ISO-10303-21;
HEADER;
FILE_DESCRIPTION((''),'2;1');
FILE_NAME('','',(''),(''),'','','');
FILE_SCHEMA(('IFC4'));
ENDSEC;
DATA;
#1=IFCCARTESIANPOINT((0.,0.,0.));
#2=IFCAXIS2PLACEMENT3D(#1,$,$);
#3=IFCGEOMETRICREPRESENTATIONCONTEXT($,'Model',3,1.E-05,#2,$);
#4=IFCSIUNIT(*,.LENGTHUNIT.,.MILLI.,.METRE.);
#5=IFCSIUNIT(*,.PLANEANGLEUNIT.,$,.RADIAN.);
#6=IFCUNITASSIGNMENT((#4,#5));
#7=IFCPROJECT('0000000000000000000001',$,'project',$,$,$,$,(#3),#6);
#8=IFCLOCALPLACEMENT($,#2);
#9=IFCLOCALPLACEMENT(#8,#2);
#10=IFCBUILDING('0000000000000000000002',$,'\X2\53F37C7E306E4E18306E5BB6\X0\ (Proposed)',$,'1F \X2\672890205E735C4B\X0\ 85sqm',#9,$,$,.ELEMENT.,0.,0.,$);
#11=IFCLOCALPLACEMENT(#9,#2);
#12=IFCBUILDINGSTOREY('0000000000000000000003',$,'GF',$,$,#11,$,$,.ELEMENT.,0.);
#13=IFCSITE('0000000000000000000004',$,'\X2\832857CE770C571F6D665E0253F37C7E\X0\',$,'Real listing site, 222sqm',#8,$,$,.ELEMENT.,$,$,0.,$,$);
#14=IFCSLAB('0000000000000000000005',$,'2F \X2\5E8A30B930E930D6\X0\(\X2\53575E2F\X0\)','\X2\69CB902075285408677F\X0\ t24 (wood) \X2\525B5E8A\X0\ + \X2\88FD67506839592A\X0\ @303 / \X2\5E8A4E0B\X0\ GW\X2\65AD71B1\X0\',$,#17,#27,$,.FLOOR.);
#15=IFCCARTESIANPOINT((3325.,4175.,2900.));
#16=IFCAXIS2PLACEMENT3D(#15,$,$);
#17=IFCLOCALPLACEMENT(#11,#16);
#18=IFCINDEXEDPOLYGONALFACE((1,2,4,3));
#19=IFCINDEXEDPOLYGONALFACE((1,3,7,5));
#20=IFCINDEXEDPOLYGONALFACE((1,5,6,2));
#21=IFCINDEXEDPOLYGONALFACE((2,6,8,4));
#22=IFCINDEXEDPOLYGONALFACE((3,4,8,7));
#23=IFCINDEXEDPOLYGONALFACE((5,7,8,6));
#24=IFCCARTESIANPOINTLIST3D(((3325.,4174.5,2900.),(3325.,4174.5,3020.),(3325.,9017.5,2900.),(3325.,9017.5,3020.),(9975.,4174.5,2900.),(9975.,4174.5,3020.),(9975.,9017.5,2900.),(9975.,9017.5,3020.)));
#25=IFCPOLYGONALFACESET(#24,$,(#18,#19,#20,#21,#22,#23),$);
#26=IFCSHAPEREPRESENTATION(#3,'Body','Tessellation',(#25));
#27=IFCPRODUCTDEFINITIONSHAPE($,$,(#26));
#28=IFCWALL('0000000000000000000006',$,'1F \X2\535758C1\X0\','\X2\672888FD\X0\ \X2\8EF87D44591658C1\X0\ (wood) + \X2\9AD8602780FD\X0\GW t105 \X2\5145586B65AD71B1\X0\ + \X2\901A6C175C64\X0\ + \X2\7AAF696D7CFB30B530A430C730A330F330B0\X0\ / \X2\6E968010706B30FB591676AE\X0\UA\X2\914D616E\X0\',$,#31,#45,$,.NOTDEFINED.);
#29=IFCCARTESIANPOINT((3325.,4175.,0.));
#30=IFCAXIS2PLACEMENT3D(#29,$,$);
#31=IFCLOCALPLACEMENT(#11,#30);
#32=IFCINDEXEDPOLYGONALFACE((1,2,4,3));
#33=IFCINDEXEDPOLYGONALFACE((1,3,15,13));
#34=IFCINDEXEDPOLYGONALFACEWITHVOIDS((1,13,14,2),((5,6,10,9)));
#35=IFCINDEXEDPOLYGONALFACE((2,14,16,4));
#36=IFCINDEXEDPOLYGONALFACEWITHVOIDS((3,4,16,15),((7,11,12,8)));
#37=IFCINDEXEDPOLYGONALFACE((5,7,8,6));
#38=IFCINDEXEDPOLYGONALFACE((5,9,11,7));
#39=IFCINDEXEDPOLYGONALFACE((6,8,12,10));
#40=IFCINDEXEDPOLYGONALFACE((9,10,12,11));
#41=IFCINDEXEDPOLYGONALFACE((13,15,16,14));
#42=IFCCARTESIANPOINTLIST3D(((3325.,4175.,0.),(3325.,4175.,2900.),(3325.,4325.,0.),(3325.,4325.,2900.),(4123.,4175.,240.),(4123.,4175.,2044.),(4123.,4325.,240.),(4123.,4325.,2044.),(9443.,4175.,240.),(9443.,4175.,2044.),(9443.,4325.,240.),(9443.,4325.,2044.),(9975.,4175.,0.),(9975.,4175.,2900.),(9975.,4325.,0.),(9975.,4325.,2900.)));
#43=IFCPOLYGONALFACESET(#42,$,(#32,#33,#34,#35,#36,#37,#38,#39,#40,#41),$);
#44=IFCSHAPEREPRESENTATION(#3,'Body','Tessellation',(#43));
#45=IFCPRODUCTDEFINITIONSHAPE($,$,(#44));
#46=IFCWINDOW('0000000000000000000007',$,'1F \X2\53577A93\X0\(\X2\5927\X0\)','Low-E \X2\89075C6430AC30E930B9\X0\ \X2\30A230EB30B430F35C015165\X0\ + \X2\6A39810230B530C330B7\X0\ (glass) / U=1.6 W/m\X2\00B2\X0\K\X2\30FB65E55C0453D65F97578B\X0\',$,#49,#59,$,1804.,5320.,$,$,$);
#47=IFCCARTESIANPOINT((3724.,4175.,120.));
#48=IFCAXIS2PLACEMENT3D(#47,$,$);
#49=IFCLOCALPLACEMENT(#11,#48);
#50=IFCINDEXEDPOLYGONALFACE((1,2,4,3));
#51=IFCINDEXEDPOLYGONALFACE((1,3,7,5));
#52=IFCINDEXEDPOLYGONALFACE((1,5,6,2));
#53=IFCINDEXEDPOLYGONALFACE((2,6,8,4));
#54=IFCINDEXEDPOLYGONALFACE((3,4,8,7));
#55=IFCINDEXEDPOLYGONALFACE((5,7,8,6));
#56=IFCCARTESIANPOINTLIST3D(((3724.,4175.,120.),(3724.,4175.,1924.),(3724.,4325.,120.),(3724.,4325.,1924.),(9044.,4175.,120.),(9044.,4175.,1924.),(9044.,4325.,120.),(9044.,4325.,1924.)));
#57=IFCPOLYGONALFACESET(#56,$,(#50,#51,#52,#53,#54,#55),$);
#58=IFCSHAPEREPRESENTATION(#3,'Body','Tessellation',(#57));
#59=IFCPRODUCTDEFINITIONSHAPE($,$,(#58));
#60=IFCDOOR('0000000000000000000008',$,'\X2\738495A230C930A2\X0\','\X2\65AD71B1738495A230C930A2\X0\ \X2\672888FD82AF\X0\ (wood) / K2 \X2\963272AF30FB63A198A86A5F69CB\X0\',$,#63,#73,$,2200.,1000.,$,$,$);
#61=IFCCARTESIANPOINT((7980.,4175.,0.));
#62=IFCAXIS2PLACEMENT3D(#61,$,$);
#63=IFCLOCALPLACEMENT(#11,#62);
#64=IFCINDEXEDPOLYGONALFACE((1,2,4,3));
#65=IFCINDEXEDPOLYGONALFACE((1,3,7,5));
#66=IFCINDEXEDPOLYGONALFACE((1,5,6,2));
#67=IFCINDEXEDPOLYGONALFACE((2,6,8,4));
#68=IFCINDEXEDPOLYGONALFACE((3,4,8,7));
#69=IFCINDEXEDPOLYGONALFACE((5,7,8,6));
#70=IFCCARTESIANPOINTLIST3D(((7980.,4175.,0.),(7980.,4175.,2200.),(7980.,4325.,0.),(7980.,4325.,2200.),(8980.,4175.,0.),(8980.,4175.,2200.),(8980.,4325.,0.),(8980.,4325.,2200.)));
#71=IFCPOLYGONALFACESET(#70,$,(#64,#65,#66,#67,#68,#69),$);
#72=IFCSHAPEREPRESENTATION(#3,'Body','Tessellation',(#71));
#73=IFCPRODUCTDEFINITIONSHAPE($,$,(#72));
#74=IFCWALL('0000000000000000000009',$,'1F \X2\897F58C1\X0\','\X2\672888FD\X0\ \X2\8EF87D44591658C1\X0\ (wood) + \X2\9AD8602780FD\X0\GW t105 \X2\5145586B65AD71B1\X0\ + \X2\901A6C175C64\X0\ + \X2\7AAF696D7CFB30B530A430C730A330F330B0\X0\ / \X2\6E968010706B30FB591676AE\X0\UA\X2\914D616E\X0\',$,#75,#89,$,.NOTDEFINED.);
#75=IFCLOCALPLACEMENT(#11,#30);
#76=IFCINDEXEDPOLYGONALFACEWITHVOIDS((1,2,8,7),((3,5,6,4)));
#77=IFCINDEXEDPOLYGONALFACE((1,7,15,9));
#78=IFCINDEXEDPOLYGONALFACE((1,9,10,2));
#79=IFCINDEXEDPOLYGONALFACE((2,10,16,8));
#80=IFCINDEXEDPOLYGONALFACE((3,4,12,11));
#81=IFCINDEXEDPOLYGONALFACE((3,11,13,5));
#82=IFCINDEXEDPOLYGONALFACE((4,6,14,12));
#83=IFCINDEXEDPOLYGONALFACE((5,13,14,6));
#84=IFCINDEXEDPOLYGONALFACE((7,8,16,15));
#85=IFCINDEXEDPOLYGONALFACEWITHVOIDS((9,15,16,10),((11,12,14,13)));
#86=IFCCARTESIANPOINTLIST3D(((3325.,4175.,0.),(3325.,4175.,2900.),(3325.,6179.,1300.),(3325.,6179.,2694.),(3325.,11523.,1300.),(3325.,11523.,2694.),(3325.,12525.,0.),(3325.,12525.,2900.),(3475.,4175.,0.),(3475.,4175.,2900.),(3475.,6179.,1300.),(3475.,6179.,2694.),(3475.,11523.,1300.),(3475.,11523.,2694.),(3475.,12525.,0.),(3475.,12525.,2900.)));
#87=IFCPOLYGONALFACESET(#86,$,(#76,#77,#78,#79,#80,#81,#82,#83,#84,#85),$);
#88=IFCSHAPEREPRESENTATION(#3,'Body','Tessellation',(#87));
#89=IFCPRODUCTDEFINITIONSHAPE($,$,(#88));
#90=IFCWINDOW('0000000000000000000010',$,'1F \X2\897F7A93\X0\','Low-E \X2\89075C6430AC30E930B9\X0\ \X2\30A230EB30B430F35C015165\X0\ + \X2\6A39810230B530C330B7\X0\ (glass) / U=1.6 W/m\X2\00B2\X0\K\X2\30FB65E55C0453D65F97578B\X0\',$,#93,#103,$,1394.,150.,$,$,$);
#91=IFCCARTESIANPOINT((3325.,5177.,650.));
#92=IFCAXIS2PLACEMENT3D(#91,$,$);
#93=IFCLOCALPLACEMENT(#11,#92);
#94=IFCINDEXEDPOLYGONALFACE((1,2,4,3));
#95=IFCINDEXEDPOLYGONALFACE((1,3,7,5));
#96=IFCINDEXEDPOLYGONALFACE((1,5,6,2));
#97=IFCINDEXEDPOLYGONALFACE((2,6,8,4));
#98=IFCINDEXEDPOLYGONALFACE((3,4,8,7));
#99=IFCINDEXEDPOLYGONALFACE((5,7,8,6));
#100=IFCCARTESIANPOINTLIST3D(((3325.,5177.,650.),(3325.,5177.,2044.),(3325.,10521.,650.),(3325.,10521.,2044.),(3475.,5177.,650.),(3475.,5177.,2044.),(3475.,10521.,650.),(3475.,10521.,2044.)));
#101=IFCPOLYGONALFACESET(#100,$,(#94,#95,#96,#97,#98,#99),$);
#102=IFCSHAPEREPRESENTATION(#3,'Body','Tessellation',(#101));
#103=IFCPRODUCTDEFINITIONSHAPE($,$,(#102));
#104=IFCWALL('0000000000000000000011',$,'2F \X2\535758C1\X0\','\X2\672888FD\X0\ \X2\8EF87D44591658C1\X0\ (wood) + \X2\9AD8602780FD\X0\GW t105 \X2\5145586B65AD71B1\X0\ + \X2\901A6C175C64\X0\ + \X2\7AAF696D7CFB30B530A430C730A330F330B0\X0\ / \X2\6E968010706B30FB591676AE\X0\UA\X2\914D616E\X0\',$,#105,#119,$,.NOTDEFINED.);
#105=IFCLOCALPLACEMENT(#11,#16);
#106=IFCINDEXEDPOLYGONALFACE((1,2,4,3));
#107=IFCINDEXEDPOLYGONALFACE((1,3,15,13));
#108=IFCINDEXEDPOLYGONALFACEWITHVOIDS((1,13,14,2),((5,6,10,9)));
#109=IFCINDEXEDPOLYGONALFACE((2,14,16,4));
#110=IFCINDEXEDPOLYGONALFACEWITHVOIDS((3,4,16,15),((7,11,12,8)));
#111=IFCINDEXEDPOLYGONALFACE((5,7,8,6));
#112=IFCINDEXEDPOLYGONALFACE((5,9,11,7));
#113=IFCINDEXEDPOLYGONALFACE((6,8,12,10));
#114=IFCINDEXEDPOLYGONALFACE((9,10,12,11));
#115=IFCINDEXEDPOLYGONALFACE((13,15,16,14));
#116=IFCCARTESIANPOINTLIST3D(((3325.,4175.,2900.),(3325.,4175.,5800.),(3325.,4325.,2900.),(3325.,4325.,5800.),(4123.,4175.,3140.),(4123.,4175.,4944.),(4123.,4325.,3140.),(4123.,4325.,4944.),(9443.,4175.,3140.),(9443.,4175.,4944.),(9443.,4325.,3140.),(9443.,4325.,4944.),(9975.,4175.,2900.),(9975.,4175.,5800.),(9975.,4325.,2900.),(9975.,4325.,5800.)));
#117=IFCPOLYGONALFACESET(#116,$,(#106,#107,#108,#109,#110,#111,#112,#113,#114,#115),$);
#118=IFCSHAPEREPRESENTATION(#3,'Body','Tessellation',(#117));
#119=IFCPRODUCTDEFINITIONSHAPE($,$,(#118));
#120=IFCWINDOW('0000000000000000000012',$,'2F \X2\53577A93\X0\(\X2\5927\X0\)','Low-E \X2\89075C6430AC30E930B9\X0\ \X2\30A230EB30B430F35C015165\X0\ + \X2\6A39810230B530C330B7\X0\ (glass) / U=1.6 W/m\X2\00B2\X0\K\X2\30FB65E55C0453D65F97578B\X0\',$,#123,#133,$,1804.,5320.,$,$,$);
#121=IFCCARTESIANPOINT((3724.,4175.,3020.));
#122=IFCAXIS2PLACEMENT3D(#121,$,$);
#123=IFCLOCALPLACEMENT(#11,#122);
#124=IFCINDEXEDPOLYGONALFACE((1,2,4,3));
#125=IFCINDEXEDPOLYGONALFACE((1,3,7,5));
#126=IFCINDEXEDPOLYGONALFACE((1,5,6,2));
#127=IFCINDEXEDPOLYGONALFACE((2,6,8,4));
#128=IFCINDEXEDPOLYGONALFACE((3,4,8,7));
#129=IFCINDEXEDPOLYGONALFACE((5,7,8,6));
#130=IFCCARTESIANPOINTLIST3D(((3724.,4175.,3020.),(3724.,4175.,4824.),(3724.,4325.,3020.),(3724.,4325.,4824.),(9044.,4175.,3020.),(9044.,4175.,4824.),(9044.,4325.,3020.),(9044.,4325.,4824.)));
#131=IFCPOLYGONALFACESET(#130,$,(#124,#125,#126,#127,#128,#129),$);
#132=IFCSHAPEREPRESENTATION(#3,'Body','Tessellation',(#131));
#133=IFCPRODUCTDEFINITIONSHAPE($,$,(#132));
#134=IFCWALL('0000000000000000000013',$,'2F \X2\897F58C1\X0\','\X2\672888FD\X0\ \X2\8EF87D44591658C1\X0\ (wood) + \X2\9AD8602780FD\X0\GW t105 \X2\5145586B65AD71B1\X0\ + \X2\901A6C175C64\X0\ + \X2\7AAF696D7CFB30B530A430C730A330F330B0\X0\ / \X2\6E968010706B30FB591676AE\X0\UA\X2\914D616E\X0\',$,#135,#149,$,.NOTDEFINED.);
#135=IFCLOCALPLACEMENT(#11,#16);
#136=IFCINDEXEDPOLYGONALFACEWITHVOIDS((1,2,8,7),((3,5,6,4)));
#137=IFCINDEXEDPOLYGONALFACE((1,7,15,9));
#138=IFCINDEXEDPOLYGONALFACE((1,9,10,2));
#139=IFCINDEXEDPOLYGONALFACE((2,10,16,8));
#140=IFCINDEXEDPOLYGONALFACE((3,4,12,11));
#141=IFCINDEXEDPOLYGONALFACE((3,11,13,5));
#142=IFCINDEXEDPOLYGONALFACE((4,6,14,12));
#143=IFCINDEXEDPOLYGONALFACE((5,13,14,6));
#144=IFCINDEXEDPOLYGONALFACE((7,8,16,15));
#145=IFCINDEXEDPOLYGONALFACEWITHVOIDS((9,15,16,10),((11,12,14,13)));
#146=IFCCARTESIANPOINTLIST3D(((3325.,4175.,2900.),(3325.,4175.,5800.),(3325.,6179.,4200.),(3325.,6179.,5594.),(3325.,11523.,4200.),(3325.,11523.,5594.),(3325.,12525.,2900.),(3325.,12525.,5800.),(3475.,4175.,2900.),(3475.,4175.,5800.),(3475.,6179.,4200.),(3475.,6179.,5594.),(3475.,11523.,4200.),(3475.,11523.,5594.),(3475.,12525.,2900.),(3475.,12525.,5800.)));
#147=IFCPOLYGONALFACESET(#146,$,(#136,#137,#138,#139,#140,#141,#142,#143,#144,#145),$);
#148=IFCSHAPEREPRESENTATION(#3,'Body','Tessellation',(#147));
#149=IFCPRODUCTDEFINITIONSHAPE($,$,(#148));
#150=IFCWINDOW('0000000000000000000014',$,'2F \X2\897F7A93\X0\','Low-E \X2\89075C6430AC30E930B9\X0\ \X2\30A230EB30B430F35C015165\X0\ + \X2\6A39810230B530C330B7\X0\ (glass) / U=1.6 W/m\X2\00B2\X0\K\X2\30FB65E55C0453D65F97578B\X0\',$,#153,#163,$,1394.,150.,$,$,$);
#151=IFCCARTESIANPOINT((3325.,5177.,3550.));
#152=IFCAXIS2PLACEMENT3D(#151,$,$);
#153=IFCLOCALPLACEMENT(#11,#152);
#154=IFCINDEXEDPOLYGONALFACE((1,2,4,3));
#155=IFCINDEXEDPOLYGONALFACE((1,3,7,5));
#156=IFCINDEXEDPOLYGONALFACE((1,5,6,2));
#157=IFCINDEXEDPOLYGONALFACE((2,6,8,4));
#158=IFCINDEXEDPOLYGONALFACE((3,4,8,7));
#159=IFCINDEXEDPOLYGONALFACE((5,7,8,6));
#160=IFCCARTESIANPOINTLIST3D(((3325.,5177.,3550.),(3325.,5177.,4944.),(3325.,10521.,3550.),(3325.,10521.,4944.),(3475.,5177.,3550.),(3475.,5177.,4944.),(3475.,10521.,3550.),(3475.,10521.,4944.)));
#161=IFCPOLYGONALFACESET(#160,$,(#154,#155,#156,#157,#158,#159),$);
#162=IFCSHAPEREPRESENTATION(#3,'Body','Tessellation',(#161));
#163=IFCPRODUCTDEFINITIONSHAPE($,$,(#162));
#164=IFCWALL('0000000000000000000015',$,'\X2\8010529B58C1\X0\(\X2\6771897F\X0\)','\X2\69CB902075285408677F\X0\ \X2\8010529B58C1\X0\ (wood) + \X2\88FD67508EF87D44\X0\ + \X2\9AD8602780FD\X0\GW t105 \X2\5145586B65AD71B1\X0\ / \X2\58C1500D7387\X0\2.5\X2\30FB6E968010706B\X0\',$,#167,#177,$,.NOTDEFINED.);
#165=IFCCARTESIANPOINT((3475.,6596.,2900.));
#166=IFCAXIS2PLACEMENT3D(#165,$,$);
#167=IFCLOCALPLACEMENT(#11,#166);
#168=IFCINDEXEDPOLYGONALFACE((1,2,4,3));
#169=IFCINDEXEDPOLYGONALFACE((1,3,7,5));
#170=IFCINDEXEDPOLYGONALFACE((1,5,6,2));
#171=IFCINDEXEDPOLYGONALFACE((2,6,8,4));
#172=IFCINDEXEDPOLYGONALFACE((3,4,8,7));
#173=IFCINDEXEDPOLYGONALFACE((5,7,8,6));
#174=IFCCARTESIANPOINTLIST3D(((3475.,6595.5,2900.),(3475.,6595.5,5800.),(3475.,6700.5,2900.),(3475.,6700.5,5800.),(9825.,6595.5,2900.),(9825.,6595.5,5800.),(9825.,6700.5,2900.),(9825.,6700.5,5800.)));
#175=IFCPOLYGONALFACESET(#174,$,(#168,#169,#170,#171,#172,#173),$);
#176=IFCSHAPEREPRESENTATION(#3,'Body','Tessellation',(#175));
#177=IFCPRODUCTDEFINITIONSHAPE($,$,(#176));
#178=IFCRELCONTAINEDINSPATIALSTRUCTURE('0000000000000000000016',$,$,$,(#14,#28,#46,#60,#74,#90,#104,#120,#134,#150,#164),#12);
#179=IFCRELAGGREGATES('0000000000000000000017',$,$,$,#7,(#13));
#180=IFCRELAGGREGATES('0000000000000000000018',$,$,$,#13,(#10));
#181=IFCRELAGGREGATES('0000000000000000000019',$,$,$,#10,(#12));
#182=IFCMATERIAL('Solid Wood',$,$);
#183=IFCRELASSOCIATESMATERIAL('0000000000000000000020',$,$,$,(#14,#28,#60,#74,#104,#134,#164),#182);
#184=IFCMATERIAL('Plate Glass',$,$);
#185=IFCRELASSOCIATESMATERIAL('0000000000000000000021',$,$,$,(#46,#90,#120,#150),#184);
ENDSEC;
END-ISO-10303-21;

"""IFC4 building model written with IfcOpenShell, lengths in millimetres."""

from ifc_helpers import new_model, si_unit, frame, frame_2d, origin, place, context, project, spatial, rectangle, extrude, material, element, fill, save


model = new_model("IFC4")

# Units and contexts
model_context = context("Model", 3, precision=1e-05, world=origin())
ifc_project = project(units=[si_unit("LENGTHUNIT", "METRE", prefix="MILLI"), si_unit("PLANEANGLEUNIT", "RADIAN")], contexts=[model_context])

# Site, building, storey
site_placement = place(None, origin())
site = spatial("IfcSite", under=ifc_project, at=site_placement, Name="茨城県土浦市右籾", ObjectType="Real listing site, 222sqm", CompositionType="ELEMENT", RefElevation=0.0)
building_placement = place(site_placement, origin())
building = spatial("IfcBuilding", under=site, at=building_placement, Name="右籾の丘の家 (Proposed)", ObjectType="1F 木造平屋 85sqm", CompositionType="ELEMENT", ElevationOfRefHeight=0.0, ElevationOfTerrain=0.0)
storey_placement = place(building_placement, origin())
storey = spatial("IfcBuildingStorey", under=building, at=storey_placement, Name="GF", CompositionType="ELEMENT", Elevation=0.0)

# Slab
ifc_material_1 = material(Name="Solid Wood")
slab_1_placement = place(storey_placement, frame((3325.0, 4175.0, 2900.0)))
element("IfcSlab", 1, at=slab_1_placement, inside=storey, material=ifc_material_1, Name="2F 床スラブ(南帯)", Description="構造用合板 t24 (wood) 剛床 + 製材根太 @303 / 床下 GW断熱", PredefinedType="FLOOR", context=model_context, shape_type="SweptSolid", body=[
    extrude(rectangle(XDim=6650.0, YDim=4843.0, at=frame_2d((3325.0, 2421.0))), frame((3325.0, 4175.0, 2900.0)), (0.0, 0.0, 1.0), 120.0),
])

# Wall, openings, window, door
wall_1_placement = place(storey_placement, frame((3325.0, 4175.0, 0.0)))
wall_1 = element("IfcWall", 2, at=wall_1_placement, inside=storey, material=ifc_material_1, Name="1F 南壁", Description="木製 軸組外壁 (wood) + 高性能GW t105 充填断熱 + 通気層 + 窯業系サイディング / 準耐火・外皮UA配慮", PredefinedType="NOTDEFINED", context=model_context, shape_type="SweptSolid", body=[
    extrude(rectangle(XDim=6650.0, YDim=150.0, at=frame_2d((3325.0, 75.0))), frame((3325.0, 4175.0, 0.0)), (0.0, 0.0, 1.0), 2900.0),
])
opening_1_placement = place(storey_placement, frame((3724.0, 4175.0, 120.0)))
opening_1 = element("IfcOpeningElement", 3, at=opening_1_placement, cuts=wall_1, PredefinedType="NOTDEFINED", context=model_context, shape_type="SweptSolid", body=[
    extrude(rectangle(XDim=5320.0, YDim=150.0, at=frame_2d((2660.0, 75.0))), frame((3724.0, 4175.0, 120.0)), (0.0, 0.0, 1.0), 1804.0),
])
opening_2_placement = place(storey_placement, frame((7980.0, 4175.0, 0.0)))
opening_2 = element("IfcOpeningElement", 4, at=opening_2_placement, cuts=wall_1, PredefinedType="NOTDEFINED", context=model_context, shape_type="SweptSolid", body=[
    extrude(rectangle(XDim=1000.0, YDim=150.0, at=frame_2d((500.0, 75.0))), frame((7980.0, 4175.0, 0.0)), (0.0, 0.0, 1.0), 2200.0),
])
ifc_material_2 = material(Name="Plate Glass")
window_1_placement = place(storey_placement, frame((3724.0, 4175.0, 120.0)))
window_1 = element("IfcWindow", 5, at=window_1_placement, inside=storey, material=ifc_material_2, Name="1F 南窓(大)", Description="Low-E 複層ガラス アルゴン封入 + 樹脂サッシ (glass) / U=1.6 W/m²K・日射取得型", OverallHeight=1804.0, OverallWidth=5320.0, context=model_context, shape_type="SweptSolid", body=[
    extrude(rectangle(XDim=5320.0, YDim=150.0, at=frame_2d((2660.0, 75.0))), frame((3724.0, 4175.0, 120.0)), (0.0, 0.0, 1.0), 1804.0),
])
fill(opening_1, window_1)
door_placement = place(storey_placement, frame((7980.0, 4175.0, 0.0)))
door = element("IfcDoor", 6, at=door_placement, inside=storey, material=ifc_material_1, Name="玄関ドア", Description="断熱玄関ドア 木製芯 (wood) / K2 防犯・採風機構", OverallHeight=2200.0, OverallWidth=1000.0, context=model_context, shape_type="SweptSolid", body=[
    extrude(rectangle(XDim=1000.0, YDim=150.0, at=frame_2d((500.0, 75.0))), frame((7980.0, 4175.0, 0.0)), (0.0, 0.0, 1.0), 2200.0),
])
fill(opening_2, door)

# Wall, opening, window
wall_2_placement = place(storey_placement, frame((3325.0, 4175.0, 0.0)))
wall_2 = element("IfcWall", 7, at=wall_2_placement, inside=storey, material=ifc_material_1, Name="1F 西壁", Description="木製 軸組外壁 (wood) + 高性能GW t105 充填断熱 + 通気層 + 窯業系サイディング / 準耐火・外皮UA配慮", PredefinedType="NOTDEFINED", context=model_context, shape_type="SweptSolid", body=[
    extrude(rectangle(XDim=150.0, YDim=8350.0, at=frame_2d((75.0, 4175.0))), frame((3325.0, 4175.0, 0.0)), (0.0, 0.0, 1.0), 2900.0),
])
opening_3_placement = place(storey_placement, frame((3325.0, 5177.0, 650.0)))
opening_3 = element("IfcOpeningElement", 8, at=opening_3_placement, cuts=wall_2, PredefinedType="NOTDEFINED", context=model_context, shape_type="SweptSolid", body=[
    extrude(rectangle(XDim=150.0, YDim=5344.0, at=frame_2d((75.0, 2672.0))), frame((3325.0, 5177.0, 650.0)), (0.0, 0.0, 1.0), 1394.0),
])
window_2_placement = place(storey_placement, frame((3325.0, 5177.0, 650.0)))
window_2 = element("IfcWindow", 9, at=window_2_placement, inside=storey, material=ifc_material_2, Name="1F 西窓", Description="Low-E 複層ガラス アルゴン封入 + 樹脂サッシ (glass) / U=1.6 W/m²K・日射取得型", OverallHeight=1394.0, OverallWidth=150.0, context=model_context, shape_type="SweptSolid", body=[
    extrude(rectangle(XDim=150.0, YDim=5344.0, at=frame_2d((75.0, 2672.0))), frame((3325.0, 5177.0, 650.0)), (0.0, 0.0, 1.0), 1394.0),
])
fill(opening_3, window_2)

# Walls, openings, windows
wall_3_placement = place(storey_placement, frame((3325.0, 4175.0, 2900.0)))
wall_3 = element("IfcWall", 10, at=wall_3_placement, inside=storey, material=ifc_material_1, Name="2F 南壁", Description="木製 軸組外壁 (wood) + 高性能GW t105 充填断熱 + 通気層 + 窯業系サイディング / 準耐火・外皮UA配慮", PredefinedType="NOTDEFINED", context=model_context, shape_type="SweptSolid", body=[
    extrude(rectangle(XDim=6650.0, YDim=150.0, at=frame_2d((3325.0, 75.0))), frame((3325.0, 4175.0, 2900.0)), (0.0, 0.0, 1.0), 2900.0),
])
opening_4_placement = place(storey_placement, frame((3724.0, 4175.0, 3020.0)))
opening_4 = element("IfcOpeningElement", 11, at=opening_4_placement, cuts=wall_3, PredefinedType="NOTDEFINED", context=model_context, shape_type="SweptSolid", body=[
    extrude(rectangle(XDim=5320.0, YDim=150.0, at=frame_2d((2660.0, 75.0))), frame((3724.0, 4175.0, 3020.0)), (0.0, 0.0, 1.0), 1804.0),
])
window_3_placement = place(storey_placement, frame((3724.0, 4175.0, 3020.0)))
window_3 = element("IfcWindow", 12, at=window_3_placement, inside=storey, material=ifc_material_2, Name="2F 南窓(大)", Description="Low-E 複層ガラス アルゴン封入 + 樹脂サッシ (glass) / U=1.6 W/m²K・日射取得型", OverallHeight=1804.0, OverallWidth=5320.0, context=model_context, shape_type="SweptSolid", body=[
    extrude(rectangle(XDim=5320.0, YDim=150.0, at=frame_2d((2660.0, 75.0))), frame((3724.0, 4175.0, 3020.0)), (0.0, 0.0, 1.0), 1804.0),
])
fill(opening_4, window_3)
wall_4_placement = place(storey_placement, frame((3325.0, 4175.0, 2900.0)))
wall_4 = element("IfcWall", 13, at=wall_4_placement, inside=storey, material=ifc_material_1, Name="2F 西壁", Description="木製 軸組外壁 (wood) + 高性能GW t105 充填断熱 + 通気層 + 窯業系サイディング / 準耐火・外皮UA配慮", PredefinedType="NOTDEFINED", context=model_context, shape_type="SweptSolid", body=[
    extrude(rectangle(XDim=150.0, YDim=8350.0, at=frame_2d((75.0, 4175.0))), frame((3325.0, 4175.0, 2900.0)), (0.0, 0.0, 1.0), 2900.0),
])
opening_5_placement = place(storey_placement, frame((3325.0, 5177.0, 3550.0)))
opening_5 = element("IfcOpeningElement", 14, at=opening_5_placement, cuts=wall_4, PredefinedType="NOTDEFINED", context=model_context, shape_type="SweptSolid", body=[
    extrude(rectangle(XDim=150.0, YDim=5344.0, at=frame_2d((75.0, 2672.0))), frame((3325.0, 5177.0, 3550.0)), (0.0, 0.0, 1.0), 1394.0),
])
window_4_placement = place(storey_placement, frame((3325.0, 5177.0, 3550.0)))
window_4 = element("IfcWindow", 15, at=window_4_placement, inside=storey, material=ifc_material_2, Name="2F 西窓", Description="Low-E 複層ガラス アルゴン封入 + 樹脂サッシ (glass) / U=1.6 W/m²K・日射取得型", OverallHeight=1394.0, OverallWidth=150.0, context=model_context, shape_type="SweptSolid", body=[
    extrude(rectangle(XDim=150.0, YDim=5344.0, at=frame_2d((75.0, 2672.0))), frame((3325.0, 5177.0, 3550.0)), (0.0, 0.0, 1.0), 1394.0),
])
fill(opening_5, window_4)

# Wall
wall_5_placement = place(storey_placement, frame((3475.0, 6596.0, 2900.0)))
element("IfcWall", 16, at=wall_5_placement, inside=storey, material=ifc_material_1, Name="耐力壁(東西)", Description="構造用合板 耐力壁 (wood) + 製材軸組 + 高性能GW t105 充填断熱 / 壁倍率2.5・準耐火", PredefinedType="NOTDEFINED", context=model_context, shape_type="SweptSolid", body=[
    extrude(rectangle(XDim=6350.0, YDim=105.0, at=frame_2d((3175.0, 52.0))), frame((3475.0, 6596.0, 2900.0)), (0.0, 0.0, 1.0), 2900.0),
])

save(model, "model.ifc")
